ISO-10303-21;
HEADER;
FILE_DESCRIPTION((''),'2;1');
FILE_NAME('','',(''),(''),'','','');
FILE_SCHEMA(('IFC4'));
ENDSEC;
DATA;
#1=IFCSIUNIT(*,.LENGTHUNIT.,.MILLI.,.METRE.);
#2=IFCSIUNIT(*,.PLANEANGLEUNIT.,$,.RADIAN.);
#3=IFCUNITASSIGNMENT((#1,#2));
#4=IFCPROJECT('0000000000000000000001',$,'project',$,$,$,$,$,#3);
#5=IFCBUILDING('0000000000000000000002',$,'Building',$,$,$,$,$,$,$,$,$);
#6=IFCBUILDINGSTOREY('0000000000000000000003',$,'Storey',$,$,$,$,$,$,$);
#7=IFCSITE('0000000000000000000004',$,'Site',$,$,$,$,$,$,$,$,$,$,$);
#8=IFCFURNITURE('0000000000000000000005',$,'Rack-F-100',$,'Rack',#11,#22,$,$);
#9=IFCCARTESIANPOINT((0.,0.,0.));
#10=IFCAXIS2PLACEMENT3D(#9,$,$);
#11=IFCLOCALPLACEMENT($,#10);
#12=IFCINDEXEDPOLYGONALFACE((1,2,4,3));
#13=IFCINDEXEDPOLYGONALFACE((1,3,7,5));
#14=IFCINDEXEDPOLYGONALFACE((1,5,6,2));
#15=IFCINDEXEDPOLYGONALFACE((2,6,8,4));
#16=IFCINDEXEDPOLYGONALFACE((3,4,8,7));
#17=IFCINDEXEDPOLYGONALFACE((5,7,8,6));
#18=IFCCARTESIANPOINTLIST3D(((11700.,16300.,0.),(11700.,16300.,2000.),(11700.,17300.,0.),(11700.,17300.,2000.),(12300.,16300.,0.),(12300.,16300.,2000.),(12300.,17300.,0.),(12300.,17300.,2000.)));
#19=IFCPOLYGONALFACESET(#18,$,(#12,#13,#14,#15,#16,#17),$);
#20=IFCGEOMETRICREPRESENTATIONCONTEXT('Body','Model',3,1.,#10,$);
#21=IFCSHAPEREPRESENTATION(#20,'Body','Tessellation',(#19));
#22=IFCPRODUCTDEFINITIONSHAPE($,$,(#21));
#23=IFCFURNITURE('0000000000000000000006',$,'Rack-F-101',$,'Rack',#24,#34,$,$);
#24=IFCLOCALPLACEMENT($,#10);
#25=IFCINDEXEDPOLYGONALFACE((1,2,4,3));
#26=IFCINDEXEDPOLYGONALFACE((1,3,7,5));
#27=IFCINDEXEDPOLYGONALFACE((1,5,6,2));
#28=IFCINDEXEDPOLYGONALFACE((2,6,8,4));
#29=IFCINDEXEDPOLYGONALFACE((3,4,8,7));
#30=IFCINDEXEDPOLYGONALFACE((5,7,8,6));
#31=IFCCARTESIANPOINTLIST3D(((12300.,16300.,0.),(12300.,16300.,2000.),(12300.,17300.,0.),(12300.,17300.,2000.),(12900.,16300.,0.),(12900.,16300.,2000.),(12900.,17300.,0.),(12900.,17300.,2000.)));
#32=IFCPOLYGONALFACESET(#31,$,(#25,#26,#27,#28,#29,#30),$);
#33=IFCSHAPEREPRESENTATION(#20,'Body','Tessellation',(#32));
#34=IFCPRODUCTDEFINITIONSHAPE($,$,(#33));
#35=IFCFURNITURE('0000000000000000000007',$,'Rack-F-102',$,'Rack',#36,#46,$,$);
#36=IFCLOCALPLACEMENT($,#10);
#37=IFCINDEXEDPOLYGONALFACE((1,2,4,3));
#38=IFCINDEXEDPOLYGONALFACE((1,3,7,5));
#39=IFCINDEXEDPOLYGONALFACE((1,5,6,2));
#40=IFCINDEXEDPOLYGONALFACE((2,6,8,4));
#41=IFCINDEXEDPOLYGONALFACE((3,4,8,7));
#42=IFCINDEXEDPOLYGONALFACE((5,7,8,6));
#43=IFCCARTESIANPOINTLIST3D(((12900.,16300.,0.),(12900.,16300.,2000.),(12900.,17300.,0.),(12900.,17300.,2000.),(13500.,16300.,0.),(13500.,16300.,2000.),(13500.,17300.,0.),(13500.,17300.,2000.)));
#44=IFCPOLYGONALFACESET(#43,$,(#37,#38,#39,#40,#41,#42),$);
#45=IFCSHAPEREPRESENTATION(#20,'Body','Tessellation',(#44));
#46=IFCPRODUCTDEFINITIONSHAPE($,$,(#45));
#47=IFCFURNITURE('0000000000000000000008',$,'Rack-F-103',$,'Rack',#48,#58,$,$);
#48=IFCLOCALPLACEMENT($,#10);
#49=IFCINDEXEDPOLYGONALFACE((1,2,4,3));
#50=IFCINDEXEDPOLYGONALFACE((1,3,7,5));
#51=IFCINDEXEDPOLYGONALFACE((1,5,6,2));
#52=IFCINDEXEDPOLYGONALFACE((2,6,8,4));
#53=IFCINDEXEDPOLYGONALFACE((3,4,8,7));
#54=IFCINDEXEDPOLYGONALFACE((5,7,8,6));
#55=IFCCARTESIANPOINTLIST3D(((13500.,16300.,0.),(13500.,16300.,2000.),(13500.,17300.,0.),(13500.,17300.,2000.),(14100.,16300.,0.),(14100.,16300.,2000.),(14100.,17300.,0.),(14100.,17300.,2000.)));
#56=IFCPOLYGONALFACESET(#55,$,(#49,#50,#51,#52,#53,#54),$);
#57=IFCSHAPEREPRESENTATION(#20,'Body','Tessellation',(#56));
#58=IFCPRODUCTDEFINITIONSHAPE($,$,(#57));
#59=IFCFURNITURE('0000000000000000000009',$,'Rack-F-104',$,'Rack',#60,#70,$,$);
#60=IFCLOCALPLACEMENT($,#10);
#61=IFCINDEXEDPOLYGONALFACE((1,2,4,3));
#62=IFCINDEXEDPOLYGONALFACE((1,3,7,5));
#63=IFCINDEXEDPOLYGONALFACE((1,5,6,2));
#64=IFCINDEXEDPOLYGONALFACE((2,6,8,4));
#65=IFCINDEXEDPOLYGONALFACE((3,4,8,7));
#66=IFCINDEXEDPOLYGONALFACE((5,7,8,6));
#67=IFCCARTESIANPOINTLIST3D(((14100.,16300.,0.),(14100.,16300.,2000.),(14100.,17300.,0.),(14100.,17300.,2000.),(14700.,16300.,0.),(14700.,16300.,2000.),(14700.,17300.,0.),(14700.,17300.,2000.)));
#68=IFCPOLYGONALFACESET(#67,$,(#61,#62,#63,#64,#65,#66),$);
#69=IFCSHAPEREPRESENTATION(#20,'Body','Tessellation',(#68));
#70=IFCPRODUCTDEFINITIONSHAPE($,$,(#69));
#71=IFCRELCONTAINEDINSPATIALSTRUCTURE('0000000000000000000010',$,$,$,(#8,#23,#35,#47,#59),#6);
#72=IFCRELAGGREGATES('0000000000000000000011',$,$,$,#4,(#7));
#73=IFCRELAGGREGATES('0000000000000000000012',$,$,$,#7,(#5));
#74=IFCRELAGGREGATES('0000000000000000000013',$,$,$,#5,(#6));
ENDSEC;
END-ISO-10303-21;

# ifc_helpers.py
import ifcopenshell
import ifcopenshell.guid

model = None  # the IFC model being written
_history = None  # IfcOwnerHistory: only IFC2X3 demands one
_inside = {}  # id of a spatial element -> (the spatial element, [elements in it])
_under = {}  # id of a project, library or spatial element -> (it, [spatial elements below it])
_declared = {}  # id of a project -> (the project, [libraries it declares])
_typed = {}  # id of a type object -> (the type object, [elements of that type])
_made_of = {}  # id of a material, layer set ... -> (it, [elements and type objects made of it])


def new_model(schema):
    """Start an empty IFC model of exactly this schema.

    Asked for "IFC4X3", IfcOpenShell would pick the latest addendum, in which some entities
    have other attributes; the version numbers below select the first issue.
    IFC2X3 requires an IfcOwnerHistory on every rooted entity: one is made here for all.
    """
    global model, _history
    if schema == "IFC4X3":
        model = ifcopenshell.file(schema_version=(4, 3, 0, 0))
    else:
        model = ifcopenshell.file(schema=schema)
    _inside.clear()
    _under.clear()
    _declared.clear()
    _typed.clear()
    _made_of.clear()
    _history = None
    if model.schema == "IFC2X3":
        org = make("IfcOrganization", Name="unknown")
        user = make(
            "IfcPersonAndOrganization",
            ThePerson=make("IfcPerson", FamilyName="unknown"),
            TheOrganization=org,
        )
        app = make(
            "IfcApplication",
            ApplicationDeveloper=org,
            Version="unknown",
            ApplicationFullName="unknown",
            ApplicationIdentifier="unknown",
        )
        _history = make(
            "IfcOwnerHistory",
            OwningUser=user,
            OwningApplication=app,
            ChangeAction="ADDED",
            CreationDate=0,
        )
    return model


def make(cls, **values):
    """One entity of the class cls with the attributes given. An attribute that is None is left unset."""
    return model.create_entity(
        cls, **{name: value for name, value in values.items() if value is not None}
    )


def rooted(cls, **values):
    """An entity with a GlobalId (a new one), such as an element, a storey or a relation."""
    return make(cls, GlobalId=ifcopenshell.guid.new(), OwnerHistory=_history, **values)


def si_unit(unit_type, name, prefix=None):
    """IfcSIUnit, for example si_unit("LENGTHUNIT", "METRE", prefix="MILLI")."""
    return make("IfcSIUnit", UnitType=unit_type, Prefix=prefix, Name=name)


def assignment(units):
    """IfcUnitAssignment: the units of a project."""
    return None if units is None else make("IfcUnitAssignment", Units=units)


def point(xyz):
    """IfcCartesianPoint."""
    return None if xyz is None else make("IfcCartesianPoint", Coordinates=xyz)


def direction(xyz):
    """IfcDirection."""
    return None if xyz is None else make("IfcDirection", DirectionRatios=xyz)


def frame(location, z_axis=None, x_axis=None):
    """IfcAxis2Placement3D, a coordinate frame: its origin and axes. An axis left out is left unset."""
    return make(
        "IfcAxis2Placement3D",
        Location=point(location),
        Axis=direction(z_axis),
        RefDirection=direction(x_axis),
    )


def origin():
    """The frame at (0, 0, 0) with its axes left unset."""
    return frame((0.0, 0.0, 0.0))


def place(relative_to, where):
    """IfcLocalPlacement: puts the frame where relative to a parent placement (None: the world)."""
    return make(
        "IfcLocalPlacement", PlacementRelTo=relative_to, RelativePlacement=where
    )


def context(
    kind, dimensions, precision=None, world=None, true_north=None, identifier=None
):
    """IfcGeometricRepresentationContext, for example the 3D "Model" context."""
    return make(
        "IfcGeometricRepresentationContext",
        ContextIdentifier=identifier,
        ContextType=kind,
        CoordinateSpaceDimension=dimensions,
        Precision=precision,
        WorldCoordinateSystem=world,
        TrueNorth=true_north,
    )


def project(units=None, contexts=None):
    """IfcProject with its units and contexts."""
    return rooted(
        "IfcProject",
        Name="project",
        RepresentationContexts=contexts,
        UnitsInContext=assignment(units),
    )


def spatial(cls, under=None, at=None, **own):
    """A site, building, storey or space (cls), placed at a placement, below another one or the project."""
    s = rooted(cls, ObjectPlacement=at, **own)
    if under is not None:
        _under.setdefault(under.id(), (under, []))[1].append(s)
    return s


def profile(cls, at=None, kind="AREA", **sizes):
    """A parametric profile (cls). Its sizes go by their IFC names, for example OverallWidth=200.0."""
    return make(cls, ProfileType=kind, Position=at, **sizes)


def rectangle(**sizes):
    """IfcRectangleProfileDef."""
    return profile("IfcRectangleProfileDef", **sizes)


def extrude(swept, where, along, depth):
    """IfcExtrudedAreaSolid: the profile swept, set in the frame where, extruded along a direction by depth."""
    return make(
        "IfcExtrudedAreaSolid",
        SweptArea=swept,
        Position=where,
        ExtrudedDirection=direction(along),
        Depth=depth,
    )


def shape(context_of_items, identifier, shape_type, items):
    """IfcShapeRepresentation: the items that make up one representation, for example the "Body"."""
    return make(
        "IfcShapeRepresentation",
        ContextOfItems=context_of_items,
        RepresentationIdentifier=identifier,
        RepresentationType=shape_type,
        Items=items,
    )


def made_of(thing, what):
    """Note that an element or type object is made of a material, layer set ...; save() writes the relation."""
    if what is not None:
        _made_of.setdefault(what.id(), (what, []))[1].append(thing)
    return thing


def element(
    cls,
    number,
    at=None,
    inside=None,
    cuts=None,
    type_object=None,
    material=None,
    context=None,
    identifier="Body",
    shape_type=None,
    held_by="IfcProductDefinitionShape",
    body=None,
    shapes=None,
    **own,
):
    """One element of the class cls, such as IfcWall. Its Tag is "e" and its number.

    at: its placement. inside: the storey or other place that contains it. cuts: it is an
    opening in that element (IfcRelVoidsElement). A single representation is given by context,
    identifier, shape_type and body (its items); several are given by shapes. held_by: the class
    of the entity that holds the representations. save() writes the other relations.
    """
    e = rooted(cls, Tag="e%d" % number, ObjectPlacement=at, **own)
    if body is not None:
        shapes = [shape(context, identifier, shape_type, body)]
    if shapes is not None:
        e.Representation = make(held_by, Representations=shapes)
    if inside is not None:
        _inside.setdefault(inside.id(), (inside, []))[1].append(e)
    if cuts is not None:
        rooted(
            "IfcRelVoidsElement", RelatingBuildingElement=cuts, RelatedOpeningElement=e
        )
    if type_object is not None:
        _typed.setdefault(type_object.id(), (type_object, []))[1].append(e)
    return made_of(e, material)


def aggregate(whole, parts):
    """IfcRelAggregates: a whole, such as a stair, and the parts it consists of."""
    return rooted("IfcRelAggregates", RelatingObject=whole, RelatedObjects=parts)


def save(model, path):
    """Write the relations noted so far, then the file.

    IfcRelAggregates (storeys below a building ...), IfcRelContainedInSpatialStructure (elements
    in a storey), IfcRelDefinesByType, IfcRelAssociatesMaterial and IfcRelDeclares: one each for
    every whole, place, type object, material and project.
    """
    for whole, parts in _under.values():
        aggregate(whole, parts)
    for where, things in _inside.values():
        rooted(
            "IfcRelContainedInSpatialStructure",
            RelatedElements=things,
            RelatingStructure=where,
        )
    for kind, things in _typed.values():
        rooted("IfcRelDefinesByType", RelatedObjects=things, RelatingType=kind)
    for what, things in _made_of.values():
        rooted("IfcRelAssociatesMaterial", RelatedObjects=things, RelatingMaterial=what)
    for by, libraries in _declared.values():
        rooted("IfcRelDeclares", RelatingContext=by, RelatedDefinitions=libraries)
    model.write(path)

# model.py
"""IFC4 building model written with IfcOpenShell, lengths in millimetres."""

from ifc_helpers import new_model, si_unit, frame, origin, place, context, project, spatial, rectangle, extrude, element, save


model = new_model("IFC4")

# Units and contexts
model_context = context("Model", 3, precision=1.0, world=origin(), identifier="Body")
ifc_project = project(units=[si_unit("LENGTHUNIT", "METRE", prefix="MILLI"), si_unit("PLANEANGLEUNIT", "RADIAN")])

# Site, building, storey
site = spatial("IfcSite", under=ifc_project, Name="Site")
building = spatial("IfcBuilding", under=site, Name="Building")
storey = spatial("IfcBuildingStorey", under=building, Name="Storey")

# Furniture
for number, where, z_axis, x_axis, name in (
    (1, (12000.0, 16800.0, 0.0), (0.0, 0.0, 1.0), (1.0, 0.0, 0.0), "Rack-F-100"),
    (2, (12600.0, 16800.0, 0.0), (0.0, 0.0, 1.0), (1.0, 0.0, 0.0), "Rack-F-101"),
    (3, (13200.0, 16800.0, 0.0), (0.0, 0.0, 1.0), (1.0, 0.0, 0.0), "Rack-F-102"),
    (4, (13800.0, 16800.0, 0.0), (0.0, 0.0, 1.0), (1.0, 0.0, 0.0), "Rack-F-103"),
    (5, (14400.0, 16800.0, 0.0), (0.0, 0.0, 1.0), (1.0, 0.0, 0.0), "Rack-F-104"),
):
    element("IfcFurniture", number, at=place(None, frame(where, z_axis=z_axis, x_axis=x_axis)), inside=storey, Name=name, ObjectType="Rack", context=model_context, shape_type="SweptSolid", body=[
        extrude(rectangle(XDim=600.0, YDim=1000.0), origin(), (0.0, 0.0, 1.0), 2000.0),
    ])

save(model, "model.ifc")
